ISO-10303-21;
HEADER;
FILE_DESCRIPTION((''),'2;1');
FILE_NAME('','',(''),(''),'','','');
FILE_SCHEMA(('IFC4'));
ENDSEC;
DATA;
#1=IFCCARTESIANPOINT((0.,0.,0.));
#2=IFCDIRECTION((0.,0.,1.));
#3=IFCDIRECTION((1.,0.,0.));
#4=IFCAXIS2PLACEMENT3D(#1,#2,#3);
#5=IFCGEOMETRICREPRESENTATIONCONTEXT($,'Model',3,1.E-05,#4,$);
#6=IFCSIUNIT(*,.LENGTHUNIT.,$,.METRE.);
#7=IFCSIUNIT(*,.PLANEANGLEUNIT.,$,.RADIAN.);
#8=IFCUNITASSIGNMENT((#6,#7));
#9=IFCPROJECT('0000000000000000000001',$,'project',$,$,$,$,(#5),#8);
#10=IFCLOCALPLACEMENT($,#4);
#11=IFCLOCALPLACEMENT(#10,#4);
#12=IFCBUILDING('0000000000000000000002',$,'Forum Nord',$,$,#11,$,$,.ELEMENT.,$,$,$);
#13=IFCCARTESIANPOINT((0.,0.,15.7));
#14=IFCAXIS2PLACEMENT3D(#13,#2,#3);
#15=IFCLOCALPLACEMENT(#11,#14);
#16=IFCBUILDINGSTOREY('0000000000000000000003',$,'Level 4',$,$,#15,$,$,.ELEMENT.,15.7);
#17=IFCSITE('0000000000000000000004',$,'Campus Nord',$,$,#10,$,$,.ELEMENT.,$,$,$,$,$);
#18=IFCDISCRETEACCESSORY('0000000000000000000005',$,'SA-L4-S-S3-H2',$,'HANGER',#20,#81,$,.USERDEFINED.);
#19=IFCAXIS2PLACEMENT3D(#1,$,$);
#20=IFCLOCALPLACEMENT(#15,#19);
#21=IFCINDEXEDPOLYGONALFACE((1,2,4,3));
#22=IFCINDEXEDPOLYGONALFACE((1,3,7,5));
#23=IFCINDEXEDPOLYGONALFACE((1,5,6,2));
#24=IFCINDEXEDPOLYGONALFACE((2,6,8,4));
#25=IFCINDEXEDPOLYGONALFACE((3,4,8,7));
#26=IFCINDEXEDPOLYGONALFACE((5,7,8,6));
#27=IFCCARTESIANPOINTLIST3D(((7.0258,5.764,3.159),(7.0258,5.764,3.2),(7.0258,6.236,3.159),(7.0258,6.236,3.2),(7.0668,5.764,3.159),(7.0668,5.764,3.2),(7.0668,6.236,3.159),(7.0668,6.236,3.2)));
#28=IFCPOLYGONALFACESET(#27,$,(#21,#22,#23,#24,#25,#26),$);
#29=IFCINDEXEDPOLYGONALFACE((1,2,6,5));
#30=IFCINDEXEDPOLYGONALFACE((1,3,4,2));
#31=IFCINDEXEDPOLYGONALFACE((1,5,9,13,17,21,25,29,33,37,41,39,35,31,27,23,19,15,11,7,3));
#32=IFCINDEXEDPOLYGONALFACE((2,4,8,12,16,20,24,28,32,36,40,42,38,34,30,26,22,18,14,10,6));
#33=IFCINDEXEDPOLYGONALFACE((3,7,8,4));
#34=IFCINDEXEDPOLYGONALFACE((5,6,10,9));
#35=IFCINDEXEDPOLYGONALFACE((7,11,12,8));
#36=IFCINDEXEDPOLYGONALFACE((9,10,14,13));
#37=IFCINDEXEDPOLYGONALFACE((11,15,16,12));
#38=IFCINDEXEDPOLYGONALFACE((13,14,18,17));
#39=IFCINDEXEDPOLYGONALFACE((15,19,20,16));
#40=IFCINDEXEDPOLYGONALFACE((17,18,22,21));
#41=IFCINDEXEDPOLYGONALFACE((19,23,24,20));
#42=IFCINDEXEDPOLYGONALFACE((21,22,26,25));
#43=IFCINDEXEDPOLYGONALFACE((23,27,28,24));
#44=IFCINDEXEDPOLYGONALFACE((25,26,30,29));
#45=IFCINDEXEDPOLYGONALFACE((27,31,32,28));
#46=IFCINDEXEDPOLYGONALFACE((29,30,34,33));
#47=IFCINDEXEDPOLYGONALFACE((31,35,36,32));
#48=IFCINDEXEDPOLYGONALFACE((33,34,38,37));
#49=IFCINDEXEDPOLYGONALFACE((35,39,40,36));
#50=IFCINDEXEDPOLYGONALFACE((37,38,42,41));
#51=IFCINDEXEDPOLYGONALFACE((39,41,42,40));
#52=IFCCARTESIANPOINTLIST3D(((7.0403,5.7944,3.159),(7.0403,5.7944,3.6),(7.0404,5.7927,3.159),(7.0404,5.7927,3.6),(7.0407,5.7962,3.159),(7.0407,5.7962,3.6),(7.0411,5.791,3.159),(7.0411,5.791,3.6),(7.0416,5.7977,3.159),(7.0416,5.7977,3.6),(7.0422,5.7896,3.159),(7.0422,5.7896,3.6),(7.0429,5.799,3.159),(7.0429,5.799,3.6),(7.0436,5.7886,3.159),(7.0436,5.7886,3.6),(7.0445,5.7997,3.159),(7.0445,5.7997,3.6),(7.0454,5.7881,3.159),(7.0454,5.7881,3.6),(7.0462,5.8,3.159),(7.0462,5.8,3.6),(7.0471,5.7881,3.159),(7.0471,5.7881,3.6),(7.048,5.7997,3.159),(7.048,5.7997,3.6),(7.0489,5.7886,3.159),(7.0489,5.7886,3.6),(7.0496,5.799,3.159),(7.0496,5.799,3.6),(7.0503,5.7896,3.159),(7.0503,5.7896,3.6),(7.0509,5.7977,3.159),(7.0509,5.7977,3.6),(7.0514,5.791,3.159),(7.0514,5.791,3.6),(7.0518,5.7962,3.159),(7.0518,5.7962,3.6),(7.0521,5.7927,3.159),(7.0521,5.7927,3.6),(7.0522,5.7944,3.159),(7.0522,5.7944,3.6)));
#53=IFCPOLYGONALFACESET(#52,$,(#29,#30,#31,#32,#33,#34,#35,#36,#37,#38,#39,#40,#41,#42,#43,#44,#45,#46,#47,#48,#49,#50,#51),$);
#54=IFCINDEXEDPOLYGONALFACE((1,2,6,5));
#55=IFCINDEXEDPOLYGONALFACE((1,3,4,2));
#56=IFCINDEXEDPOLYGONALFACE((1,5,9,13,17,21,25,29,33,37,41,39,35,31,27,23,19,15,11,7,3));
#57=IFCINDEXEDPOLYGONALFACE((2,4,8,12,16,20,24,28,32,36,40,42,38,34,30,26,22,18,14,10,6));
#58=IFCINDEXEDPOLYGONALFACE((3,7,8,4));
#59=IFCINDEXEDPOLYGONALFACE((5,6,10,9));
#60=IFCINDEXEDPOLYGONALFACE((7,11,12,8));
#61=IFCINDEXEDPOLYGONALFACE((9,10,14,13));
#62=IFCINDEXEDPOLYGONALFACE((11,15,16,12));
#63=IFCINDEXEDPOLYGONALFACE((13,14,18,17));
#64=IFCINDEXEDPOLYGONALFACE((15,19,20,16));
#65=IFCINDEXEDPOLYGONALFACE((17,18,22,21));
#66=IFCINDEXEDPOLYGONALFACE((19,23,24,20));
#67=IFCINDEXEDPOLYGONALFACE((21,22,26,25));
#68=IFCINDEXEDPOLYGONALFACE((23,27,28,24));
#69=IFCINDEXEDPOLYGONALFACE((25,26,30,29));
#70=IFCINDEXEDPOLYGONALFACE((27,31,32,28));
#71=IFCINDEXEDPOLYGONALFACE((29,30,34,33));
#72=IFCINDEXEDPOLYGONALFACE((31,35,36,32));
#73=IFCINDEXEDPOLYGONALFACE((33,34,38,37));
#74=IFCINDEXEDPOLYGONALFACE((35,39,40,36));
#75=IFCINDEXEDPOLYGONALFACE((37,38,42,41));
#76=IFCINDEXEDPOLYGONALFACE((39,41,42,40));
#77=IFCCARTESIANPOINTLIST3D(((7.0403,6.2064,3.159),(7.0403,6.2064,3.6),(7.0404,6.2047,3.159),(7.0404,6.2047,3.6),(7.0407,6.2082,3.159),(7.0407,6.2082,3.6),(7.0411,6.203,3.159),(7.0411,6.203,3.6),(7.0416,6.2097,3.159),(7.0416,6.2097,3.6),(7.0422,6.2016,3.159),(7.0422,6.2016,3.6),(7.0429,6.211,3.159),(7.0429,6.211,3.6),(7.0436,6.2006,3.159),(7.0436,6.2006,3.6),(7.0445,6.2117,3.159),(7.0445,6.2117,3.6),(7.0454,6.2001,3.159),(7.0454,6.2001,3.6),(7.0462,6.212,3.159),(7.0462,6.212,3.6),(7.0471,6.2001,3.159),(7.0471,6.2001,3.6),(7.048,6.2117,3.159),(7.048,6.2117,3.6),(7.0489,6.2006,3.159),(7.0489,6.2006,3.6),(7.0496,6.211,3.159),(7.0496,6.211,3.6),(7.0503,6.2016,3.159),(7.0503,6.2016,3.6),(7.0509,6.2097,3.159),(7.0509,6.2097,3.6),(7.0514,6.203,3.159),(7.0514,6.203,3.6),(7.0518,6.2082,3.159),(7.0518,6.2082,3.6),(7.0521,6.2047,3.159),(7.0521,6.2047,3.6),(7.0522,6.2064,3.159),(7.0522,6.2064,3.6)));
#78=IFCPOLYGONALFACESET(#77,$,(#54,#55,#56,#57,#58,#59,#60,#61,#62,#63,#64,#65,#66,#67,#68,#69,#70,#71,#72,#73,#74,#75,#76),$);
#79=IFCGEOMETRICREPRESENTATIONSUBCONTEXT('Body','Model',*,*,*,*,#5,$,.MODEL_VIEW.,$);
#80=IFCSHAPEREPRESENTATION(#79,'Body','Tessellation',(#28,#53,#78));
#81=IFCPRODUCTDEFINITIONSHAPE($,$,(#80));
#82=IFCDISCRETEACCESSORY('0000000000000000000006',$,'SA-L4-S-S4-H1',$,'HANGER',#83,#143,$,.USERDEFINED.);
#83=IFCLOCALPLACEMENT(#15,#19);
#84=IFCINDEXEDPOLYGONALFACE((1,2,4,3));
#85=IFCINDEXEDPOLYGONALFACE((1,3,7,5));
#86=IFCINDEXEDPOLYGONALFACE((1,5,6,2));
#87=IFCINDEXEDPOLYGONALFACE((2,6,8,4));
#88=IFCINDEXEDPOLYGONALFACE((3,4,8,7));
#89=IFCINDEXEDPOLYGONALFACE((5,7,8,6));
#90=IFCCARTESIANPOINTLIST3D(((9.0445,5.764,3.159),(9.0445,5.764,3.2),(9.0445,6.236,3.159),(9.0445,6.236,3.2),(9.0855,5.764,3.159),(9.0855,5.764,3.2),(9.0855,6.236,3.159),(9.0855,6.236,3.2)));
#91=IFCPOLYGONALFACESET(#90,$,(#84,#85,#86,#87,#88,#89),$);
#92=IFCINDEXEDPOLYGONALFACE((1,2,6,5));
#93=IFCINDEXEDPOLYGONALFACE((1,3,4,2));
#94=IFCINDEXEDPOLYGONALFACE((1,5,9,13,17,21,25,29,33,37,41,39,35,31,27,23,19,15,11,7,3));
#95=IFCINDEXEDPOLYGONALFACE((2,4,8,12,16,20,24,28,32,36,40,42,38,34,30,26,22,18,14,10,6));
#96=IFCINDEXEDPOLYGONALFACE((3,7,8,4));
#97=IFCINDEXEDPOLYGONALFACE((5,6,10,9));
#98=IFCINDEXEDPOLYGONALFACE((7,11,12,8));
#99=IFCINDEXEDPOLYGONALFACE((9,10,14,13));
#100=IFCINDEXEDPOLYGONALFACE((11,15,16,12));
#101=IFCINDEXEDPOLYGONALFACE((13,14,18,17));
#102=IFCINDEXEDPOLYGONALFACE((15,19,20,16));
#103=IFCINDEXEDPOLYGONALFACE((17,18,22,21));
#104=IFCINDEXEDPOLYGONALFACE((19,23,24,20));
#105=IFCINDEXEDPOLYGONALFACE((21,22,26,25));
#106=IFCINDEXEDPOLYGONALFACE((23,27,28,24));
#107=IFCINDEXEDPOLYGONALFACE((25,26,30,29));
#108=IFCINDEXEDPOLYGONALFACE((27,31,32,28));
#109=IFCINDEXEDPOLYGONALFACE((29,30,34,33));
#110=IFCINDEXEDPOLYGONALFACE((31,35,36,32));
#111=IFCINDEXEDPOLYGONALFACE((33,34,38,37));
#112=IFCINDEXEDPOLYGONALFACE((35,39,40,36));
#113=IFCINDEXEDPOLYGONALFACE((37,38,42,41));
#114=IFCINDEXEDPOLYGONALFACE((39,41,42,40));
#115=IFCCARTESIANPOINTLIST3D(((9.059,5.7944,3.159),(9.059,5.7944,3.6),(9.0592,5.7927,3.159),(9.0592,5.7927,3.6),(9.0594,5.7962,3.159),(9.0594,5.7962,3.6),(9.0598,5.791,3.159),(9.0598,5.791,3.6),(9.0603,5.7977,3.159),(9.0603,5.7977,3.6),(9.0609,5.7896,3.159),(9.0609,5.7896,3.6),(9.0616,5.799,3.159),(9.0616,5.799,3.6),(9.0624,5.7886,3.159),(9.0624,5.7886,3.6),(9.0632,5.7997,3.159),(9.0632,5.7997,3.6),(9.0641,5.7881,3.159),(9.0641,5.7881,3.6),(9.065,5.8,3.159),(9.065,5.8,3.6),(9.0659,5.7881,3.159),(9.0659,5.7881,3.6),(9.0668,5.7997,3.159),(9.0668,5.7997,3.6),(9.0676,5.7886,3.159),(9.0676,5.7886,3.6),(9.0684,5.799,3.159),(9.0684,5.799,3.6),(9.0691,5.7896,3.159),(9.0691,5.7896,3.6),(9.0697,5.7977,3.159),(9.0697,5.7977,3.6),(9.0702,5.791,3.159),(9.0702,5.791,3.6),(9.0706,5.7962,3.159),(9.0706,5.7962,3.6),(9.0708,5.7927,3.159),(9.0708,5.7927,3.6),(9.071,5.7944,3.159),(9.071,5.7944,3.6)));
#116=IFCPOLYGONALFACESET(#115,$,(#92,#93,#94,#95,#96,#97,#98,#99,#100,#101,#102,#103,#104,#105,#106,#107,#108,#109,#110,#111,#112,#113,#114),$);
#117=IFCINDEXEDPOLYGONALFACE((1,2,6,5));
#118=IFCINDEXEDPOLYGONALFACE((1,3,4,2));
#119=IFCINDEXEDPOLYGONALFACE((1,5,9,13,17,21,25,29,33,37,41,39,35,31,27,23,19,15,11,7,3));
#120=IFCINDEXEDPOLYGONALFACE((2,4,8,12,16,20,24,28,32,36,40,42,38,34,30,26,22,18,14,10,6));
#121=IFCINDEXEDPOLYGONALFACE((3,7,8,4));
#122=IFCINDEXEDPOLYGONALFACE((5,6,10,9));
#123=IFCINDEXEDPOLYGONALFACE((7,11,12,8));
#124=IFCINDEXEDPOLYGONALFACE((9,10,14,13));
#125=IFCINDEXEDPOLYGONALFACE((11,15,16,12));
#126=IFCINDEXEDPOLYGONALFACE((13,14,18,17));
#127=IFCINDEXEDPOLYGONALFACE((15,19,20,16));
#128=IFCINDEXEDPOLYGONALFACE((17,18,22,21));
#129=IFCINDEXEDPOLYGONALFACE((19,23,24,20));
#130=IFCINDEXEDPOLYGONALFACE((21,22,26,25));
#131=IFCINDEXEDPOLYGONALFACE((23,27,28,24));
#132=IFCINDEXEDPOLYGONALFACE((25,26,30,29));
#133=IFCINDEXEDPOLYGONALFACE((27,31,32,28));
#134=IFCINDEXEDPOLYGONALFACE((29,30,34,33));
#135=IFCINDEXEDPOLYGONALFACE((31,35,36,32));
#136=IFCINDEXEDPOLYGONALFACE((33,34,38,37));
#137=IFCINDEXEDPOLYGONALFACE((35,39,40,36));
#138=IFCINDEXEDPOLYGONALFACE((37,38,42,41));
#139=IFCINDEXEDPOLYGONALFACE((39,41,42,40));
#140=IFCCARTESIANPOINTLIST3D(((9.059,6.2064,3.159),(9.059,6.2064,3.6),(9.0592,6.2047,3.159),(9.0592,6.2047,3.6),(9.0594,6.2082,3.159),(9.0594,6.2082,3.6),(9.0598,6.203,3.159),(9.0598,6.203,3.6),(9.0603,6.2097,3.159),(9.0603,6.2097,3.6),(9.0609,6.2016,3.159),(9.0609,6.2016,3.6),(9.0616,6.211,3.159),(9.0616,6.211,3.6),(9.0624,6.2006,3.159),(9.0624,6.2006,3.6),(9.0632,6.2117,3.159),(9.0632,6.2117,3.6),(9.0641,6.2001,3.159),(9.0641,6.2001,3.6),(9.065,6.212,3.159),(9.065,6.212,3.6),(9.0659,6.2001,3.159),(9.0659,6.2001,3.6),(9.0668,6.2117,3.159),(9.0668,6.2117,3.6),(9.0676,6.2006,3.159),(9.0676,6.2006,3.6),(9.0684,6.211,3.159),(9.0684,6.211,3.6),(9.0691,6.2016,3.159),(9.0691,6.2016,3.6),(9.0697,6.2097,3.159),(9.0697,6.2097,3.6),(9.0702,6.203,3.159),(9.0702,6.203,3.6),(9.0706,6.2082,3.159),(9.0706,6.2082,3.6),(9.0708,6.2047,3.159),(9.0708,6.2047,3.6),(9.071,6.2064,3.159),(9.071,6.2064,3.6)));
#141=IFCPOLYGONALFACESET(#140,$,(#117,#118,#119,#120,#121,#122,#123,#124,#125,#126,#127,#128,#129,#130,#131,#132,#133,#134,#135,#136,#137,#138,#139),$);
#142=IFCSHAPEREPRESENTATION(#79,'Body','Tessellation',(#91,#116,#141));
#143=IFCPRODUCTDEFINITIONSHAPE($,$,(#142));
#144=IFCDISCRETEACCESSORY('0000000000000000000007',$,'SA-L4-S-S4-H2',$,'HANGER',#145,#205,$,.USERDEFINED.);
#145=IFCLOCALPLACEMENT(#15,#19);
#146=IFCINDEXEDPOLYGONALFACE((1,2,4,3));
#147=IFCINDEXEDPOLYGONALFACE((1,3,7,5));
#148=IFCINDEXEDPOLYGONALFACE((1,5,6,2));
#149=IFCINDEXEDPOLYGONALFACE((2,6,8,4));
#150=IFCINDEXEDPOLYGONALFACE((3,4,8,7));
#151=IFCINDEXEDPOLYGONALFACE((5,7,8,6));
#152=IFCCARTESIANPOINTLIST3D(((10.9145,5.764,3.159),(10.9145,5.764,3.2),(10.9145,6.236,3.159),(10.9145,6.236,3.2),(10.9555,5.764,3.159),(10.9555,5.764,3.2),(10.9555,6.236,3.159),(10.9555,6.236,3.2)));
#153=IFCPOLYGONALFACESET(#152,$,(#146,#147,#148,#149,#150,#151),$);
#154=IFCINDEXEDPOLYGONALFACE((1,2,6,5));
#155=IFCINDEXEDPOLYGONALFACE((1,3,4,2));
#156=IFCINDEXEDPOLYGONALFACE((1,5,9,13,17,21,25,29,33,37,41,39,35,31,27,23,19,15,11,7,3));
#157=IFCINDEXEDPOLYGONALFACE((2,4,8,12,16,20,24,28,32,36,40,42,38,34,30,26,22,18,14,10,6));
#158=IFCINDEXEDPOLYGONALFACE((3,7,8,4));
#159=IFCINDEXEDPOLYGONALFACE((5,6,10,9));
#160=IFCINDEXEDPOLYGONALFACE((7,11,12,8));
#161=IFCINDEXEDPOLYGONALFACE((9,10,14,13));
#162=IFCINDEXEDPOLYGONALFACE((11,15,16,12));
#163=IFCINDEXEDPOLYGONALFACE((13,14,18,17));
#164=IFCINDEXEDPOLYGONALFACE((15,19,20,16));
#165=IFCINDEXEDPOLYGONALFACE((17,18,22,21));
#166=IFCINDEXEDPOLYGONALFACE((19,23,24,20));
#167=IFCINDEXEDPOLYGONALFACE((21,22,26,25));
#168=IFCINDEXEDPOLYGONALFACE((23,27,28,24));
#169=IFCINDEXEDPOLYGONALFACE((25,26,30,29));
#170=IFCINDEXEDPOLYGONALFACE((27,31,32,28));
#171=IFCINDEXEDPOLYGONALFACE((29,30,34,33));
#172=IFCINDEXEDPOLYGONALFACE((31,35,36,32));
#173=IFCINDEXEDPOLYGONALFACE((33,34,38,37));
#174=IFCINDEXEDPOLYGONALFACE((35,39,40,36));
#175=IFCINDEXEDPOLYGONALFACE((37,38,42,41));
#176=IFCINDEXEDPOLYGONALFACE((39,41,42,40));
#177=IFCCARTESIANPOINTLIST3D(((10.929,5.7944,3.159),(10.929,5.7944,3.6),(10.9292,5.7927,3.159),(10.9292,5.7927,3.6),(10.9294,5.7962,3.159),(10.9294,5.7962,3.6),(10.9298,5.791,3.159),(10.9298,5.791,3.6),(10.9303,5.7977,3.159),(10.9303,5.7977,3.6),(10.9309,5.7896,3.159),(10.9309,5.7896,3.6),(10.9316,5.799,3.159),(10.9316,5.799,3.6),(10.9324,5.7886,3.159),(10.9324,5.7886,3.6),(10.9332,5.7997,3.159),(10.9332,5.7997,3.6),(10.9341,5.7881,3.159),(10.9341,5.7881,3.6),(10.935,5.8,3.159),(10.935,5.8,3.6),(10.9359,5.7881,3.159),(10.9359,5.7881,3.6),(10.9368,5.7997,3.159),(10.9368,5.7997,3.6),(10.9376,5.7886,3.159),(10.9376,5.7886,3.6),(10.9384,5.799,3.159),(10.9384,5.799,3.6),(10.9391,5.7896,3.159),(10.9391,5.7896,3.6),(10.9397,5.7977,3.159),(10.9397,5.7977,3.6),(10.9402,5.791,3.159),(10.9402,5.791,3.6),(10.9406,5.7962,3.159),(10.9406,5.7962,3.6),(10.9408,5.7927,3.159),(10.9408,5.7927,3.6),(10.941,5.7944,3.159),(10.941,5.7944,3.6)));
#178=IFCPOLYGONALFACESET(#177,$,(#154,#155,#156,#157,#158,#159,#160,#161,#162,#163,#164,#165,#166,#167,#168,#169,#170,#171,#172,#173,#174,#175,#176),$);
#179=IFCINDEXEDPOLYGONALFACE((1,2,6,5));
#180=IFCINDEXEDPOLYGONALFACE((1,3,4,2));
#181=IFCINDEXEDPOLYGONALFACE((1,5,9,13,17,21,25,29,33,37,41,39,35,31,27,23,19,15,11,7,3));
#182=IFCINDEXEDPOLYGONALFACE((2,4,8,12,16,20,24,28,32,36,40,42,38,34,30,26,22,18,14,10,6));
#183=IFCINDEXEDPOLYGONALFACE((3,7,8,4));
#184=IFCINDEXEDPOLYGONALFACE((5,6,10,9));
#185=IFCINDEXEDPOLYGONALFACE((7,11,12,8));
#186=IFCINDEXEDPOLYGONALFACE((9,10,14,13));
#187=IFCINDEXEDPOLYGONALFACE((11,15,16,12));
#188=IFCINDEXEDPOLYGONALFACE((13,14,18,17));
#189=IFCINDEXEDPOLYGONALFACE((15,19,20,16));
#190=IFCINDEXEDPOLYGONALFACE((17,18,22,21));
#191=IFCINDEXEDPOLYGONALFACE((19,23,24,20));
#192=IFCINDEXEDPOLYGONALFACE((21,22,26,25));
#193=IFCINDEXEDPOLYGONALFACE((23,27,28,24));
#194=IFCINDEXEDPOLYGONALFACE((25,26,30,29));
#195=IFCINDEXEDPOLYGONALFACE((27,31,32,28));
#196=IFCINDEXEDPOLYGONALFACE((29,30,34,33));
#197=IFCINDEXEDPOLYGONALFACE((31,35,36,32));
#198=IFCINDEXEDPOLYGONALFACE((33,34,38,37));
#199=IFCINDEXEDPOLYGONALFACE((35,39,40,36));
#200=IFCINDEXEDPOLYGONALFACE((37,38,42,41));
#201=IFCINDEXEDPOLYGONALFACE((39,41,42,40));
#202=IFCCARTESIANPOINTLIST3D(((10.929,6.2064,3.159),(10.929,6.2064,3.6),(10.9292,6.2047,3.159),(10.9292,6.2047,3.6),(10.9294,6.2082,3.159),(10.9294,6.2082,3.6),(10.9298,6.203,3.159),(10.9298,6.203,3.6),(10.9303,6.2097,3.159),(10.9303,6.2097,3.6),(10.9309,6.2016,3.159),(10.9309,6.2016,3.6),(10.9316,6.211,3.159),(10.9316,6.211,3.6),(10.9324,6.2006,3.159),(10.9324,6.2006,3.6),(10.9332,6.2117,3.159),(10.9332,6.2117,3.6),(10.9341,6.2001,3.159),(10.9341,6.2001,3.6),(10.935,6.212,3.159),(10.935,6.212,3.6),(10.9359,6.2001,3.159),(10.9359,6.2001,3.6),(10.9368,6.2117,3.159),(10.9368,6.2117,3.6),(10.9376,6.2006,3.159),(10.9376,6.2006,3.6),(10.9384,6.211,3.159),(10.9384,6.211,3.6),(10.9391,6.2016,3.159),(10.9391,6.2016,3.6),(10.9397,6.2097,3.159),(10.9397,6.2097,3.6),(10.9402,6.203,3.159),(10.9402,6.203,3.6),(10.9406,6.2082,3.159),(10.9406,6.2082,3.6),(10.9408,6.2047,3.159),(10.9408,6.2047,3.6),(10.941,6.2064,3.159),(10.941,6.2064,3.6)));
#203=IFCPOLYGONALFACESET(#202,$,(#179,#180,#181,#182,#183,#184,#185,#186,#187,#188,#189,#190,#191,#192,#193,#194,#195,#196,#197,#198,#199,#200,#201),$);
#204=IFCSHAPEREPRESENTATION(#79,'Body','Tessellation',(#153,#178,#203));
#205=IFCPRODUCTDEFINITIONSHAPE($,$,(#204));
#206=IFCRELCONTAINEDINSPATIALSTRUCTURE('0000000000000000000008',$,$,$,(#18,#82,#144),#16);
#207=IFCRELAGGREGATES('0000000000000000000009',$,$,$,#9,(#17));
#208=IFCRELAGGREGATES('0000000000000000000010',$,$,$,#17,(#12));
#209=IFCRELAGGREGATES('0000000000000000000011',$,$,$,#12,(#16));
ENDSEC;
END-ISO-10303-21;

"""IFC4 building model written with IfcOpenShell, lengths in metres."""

from ifc_helpers import new_model, si_unit, frame, frame_2d, origin_with_axes, origin_2d_with_axis, place, context, subcontext, project, spatial, rectangle, circle, extrude, element, save


model = new_model("IFC4")

# Units and contexts
model_context = context("Model", 3, precision=1e-05, world=origin_with_axes())
body_context = subcontext(model_context, "Body", "Model", "MODEL_VIEW")
ifc_project = project(units=[si_unit("LENGTHUNIT", "METRE"), si_unit("PLANEANGLEUNIT", "RADIAN")], contexts=[model_context])

# Site, building, storey
site_placement = place(None, origin_with_axes())
site = spatial("IfcSite", under=ifc_project, at=site_placement, Name="Campus Nord", CompositionType="ELEMENT")
building_placement = place(site_placement, origin_with_axes())
building = spatial("IfcBuilding", under=site, at=building_placement, Name="Forum Nord", CompositionType="ELEMENT")
storey_placement = place(building_placement, frame((0.0, 0.0, 15.7), z_axis=(0.0, 0.0, 1.0), x_axis=(1.0, 0.0, 0.0)))
storey = spatial("IfcBuildingStorey", under=building, at=storey_placement, Name="Level 4", CompositionType="ELEMENT", Elevation=15.7)

# Discrete accessories
for number, where, z_axis, x_axis, name in (
    (1, (7.0462, 6.0, 3.2), (0.0, 0.0, 1.0), (0.0, 1.0, 0.0), "SA-L4-S-S3-H2"),
    (2, (9.065, 6.0, 3.2), (0.0, 0.0, 1.0), (0.0, 1.0, 0.0), "SA-L4-S-S4-H1"),
    (3, (10.935, 6.0, 3.2), (0.0, 0.0, 1.0), (0.0, 1.0, 0.0), "SA-L4-S-S4-H2"),
):
    element("IfcDiscreteAccessory", number, at=place(storey_placement, frame(where, z_axis=z_axis, x_axis=x_axis)), inside=storey, Name=name, ObjectType="HANGER", PredefinedType="USERDEFINED", context=body_context, shape_type="SweptSolid", body=[
        extrude(rectangle(XDim=0.472, YDim=0.041, at=origin_2d_with_axis()), frame((0.0, 0.0, -0.041), z_axis=(0.0, 0.0, 1.0), x_axis=(1.0, 0.0, 0.0)), (0.0, 0.0, 1.0), 0.041),
        extrude(circle(Radius=0.006, at=frame_2d((-0.206, 0.0), x_axis=(1.0, 0.0))), frame((0.0, 0.0, -0.041), z_axis=(0.0, 0.0, 1.0), x_axis=(1.0, 0.0, 0.0)), (0.0, 0.0, 1.0), 0.441),
        extrude(circle(Radius=0.006, at=frame_2d((0.206, 0.0), x_axis=(1.0, 0.0))), frame((0.0, 0.0, -0.041), z_axis=(0.0, 0.0, 1.0), x_axis=(1.0, 0.0, 0.0)), (0.0, 0.0, 1.0), 0.441),
    ])

save(model, "model.ifc")
